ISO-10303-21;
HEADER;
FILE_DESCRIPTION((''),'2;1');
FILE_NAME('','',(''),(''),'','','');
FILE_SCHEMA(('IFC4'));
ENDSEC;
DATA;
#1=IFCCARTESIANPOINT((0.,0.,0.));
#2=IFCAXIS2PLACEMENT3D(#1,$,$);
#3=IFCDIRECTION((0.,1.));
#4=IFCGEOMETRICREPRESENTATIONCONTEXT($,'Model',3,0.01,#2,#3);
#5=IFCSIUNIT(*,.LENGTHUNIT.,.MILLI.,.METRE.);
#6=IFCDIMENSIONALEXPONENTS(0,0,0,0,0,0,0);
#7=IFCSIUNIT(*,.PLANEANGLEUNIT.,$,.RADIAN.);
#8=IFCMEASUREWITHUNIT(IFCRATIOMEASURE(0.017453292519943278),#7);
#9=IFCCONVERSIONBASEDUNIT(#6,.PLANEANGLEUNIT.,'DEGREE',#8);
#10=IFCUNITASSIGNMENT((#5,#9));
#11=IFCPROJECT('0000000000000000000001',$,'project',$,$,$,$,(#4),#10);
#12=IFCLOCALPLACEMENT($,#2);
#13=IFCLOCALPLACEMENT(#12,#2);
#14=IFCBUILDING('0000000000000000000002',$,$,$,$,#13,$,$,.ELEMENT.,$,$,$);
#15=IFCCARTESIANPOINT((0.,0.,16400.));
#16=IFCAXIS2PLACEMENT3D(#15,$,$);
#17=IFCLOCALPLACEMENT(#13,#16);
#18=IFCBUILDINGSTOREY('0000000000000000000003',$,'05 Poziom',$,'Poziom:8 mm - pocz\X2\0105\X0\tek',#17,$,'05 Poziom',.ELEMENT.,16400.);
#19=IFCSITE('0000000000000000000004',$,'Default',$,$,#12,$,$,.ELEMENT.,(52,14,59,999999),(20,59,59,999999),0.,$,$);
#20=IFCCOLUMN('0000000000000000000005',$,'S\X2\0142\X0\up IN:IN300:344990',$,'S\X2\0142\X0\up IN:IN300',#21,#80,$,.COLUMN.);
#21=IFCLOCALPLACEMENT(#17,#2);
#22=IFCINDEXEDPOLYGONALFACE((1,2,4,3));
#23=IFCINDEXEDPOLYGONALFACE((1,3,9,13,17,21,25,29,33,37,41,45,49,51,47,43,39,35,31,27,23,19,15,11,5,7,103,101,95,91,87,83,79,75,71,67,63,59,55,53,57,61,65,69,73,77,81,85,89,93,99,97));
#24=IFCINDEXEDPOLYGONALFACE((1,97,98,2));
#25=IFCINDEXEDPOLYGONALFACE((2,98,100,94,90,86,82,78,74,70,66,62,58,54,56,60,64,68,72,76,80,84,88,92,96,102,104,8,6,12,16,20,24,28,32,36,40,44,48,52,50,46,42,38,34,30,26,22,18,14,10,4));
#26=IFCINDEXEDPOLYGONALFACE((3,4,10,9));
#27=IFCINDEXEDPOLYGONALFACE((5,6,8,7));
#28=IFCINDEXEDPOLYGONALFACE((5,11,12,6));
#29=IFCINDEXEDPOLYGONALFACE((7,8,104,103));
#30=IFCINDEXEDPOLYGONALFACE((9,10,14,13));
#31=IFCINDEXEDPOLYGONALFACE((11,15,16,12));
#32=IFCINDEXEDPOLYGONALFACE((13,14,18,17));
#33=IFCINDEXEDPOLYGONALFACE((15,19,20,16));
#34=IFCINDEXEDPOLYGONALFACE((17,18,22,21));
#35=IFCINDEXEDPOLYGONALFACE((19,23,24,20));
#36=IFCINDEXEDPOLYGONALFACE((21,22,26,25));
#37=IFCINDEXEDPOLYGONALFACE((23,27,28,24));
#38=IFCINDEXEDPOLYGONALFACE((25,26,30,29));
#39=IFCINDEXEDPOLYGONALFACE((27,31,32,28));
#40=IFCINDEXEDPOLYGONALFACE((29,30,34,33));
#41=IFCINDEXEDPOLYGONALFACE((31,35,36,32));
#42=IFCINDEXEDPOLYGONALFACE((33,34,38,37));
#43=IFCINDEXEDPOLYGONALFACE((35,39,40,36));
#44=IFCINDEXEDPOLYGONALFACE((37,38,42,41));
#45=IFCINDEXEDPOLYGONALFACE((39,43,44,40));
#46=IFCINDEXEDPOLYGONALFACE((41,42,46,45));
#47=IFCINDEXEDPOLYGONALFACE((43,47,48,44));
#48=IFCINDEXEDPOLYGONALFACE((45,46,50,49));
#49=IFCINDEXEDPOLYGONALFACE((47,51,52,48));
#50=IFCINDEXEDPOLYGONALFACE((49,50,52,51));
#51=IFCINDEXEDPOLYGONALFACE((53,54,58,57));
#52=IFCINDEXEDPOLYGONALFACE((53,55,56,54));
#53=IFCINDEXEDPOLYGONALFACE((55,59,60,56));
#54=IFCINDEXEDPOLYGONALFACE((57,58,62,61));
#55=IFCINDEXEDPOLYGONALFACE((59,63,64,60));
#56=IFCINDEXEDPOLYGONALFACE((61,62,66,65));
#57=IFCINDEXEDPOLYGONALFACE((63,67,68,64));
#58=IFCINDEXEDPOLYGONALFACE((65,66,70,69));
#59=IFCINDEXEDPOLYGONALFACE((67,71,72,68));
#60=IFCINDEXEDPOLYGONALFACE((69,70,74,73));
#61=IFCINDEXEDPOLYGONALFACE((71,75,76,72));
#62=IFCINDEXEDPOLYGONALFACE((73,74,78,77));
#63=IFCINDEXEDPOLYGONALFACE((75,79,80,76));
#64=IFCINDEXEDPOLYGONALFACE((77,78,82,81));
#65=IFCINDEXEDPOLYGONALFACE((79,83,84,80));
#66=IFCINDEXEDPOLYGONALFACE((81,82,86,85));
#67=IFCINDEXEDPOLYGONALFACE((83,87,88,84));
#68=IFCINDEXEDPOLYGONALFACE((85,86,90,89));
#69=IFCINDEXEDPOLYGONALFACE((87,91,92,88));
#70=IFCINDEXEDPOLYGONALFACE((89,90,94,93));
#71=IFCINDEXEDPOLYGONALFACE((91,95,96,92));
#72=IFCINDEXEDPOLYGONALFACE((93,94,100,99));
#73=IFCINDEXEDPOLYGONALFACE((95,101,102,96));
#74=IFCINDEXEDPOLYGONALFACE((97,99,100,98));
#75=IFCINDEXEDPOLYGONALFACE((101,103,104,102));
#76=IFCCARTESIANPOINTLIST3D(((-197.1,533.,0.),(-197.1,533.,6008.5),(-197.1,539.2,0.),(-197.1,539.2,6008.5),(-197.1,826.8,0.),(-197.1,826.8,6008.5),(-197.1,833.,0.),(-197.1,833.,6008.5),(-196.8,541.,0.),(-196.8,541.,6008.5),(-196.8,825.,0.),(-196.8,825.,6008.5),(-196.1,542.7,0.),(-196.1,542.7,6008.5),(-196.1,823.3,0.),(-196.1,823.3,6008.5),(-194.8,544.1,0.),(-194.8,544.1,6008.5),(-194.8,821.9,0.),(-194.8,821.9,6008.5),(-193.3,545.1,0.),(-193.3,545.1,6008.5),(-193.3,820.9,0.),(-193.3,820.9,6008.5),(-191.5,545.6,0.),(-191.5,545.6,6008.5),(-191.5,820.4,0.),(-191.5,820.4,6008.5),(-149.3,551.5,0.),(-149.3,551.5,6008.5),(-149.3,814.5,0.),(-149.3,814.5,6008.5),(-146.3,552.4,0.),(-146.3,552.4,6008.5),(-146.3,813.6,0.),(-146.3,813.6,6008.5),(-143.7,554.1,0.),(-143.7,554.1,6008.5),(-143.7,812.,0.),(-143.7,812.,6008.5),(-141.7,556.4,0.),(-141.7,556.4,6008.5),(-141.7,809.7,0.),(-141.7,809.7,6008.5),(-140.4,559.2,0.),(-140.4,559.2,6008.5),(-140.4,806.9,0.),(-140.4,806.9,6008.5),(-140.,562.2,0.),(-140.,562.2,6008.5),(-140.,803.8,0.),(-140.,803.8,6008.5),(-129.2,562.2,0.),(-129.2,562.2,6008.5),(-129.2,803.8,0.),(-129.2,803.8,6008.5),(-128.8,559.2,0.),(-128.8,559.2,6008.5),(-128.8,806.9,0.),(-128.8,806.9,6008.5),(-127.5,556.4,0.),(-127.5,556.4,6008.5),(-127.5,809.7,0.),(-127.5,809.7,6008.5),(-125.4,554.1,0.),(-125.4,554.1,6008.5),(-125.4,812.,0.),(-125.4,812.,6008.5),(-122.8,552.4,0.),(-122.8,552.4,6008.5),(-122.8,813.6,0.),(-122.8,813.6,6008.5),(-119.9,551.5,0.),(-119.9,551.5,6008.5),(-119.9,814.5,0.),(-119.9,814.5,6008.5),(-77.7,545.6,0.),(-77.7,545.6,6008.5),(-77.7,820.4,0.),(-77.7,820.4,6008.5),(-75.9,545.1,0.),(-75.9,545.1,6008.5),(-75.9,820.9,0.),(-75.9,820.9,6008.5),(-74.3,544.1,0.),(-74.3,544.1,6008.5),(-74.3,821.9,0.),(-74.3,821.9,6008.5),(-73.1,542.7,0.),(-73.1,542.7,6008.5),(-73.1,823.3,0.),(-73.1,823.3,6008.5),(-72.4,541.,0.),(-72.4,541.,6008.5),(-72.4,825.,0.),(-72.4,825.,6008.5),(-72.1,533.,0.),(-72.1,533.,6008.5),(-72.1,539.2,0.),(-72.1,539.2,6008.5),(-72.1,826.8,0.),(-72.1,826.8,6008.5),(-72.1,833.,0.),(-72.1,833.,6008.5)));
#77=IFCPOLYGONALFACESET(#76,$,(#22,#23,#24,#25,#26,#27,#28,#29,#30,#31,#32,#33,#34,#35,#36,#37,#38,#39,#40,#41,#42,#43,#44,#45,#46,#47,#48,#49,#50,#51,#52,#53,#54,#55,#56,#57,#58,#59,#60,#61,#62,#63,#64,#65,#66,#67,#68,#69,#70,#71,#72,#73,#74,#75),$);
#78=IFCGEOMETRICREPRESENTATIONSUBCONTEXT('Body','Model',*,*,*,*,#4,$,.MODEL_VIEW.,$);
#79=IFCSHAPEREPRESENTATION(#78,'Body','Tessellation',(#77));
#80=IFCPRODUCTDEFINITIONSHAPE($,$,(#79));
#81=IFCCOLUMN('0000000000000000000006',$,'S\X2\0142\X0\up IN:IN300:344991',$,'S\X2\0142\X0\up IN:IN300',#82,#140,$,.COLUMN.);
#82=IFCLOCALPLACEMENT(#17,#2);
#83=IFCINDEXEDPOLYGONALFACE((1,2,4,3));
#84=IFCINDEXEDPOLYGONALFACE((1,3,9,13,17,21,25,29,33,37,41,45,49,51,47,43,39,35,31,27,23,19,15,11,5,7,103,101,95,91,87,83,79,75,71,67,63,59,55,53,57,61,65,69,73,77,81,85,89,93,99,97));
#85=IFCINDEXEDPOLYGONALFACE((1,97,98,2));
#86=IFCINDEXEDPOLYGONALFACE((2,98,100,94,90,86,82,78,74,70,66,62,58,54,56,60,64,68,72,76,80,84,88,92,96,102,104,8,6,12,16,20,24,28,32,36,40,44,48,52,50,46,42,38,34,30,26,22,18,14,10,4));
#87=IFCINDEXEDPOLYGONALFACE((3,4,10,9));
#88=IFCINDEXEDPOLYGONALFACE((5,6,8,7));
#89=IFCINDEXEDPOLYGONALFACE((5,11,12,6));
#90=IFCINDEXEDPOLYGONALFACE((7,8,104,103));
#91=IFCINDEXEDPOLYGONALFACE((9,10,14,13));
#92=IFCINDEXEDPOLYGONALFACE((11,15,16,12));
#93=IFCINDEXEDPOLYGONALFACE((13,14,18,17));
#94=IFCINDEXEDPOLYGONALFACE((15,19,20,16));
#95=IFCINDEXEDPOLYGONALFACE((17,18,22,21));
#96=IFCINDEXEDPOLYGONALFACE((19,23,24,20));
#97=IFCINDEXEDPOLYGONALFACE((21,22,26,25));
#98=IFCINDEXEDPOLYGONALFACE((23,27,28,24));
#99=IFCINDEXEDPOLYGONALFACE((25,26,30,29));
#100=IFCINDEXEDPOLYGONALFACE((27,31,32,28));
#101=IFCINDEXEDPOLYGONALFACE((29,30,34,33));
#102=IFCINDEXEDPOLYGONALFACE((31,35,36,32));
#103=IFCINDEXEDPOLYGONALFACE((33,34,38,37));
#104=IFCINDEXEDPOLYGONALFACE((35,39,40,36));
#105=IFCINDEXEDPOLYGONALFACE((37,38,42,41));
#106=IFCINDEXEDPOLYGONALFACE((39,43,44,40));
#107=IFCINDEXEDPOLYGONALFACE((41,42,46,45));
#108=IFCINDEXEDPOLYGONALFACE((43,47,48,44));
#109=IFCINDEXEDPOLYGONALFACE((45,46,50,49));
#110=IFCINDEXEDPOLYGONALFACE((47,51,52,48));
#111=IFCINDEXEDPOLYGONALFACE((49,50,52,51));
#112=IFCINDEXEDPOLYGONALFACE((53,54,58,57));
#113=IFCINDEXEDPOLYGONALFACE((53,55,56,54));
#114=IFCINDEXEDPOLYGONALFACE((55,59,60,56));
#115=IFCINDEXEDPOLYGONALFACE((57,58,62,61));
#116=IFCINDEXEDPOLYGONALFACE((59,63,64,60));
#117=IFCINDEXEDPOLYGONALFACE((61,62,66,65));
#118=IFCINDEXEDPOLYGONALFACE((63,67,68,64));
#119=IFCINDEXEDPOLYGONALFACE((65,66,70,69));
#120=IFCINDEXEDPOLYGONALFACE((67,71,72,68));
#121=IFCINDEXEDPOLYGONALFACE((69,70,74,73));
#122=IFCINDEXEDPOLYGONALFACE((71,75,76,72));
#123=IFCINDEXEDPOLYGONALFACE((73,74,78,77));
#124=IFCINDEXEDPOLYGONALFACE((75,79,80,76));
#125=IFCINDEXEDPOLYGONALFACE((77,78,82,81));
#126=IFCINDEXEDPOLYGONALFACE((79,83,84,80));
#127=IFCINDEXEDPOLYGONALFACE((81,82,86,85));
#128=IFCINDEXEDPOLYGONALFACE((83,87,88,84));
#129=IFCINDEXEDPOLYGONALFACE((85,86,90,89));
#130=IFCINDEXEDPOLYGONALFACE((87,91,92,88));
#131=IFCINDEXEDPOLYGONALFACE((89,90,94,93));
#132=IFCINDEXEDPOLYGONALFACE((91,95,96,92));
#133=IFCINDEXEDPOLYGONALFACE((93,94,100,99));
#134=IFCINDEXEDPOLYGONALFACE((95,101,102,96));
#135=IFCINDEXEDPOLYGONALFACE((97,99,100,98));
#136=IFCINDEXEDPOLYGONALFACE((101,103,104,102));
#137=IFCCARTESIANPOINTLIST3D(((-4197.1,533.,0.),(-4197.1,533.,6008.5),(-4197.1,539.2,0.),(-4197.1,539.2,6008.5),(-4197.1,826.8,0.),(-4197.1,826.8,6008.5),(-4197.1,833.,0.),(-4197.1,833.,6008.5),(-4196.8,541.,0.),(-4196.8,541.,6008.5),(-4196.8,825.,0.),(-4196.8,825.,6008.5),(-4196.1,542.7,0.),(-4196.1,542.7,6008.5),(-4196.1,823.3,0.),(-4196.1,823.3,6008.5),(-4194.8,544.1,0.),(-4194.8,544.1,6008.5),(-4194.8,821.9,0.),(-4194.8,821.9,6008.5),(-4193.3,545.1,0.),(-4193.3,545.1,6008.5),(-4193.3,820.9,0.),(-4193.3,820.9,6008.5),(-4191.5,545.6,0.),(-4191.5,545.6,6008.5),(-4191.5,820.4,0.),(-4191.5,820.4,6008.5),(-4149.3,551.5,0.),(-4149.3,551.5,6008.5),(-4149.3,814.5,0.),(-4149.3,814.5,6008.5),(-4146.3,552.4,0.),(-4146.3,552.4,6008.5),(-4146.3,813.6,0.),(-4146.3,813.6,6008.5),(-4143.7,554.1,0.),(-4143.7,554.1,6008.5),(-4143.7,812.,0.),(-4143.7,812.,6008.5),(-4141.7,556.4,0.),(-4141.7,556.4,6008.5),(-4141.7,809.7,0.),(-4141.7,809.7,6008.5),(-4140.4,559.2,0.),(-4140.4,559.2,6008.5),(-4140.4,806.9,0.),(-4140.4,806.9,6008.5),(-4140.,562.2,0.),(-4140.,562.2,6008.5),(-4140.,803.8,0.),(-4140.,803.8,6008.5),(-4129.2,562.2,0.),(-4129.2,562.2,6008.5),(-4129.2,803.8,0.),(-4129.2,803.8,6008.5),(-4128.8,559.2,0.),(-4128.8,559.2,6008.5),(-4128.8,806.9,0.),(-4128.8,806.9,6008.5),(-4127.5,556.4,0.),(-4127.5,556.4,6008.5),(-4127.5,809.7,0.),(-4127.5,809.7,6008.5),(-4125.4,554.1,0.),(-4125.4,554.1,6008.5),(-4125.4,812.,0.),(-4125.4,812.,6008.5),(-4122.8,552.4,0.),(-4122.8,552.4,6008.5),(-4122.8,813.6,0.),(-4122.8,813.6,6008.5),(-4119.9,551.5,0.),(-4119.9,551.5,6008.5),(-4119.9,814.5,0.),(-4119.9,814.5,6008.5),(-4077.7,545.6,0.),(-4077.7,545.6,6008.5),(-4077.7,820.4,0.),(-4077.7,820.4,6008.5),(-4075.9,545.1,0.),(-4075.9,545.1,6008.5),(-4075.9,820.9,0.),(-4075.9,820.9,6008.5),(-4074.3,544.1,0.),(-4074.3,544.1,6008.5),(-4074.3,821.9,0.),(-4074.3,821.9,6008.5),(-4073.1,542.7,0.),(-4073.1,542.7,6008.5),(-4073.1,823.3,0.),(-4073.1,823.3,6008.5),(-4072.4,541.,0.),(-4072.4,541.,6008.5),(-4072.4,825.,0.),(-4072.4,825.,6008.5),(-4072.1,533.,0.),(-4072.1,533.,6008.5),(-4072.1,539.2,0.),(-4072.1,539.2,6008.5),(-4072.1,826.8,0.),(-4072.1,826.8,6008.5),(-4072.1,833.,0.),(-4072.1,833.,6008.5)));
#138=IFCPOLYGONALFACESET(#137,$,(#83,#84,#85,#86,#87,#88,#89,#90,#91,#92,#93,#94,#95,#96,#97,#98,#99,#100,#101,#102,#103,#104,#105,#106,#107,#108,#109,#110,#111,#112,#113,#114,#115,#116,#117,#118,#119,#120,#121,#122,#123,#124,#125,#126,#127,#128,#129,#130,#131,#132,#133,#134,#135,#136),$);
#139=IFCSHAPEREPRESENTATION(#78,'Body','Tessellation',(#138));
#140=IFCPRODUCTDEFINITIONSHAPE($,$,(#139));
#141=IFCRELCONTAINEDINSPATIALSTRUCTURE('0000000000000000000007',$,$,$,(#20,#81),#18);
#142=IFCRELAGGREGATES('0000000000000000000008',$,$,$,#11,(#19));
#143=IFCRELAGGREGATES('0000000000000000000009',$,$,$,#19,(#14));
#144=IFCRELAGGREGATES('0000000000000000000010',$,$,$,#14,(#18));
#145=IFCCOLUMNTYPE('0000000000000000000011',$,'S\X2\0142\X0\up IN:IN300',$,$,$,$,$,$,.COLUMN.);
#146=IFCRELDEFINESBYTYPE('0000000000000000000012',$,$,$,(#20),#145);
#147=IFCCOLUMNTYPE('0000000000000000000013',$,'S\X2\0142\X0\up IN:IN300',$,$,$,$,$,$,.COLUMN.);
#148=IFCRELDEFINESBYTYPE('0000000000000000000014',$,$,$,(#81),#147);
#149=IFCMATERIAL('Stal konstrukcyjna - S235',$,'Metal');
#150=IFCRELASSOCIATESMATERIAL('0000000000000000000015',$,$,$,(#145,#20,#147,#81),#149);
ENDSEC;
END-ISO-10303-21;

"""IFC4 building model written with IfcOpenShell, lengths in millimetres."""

from ifc_helpers import new_model, entity, si_unit, converted_unit, direction, frame, origin, place, context, subcontext, project, spatial, line, arc, indexed_curve, outline, extrude, source, transform, mapped, material, type_object, type_shapes, element, save


model = new_model("IFC4")

# Units and contexts
model_context = context("Model", 3, precision=0.01, world=origin(), true_north=direction((0.0, 1.0)))
body_context = subcontext(model_context, "Body", "Model", "MODEL_VIEW")
ifc_project = project(units=[si_unit("LENGTHUNIT", "METRE", prefix="MILLI"), converted_unit("PLANEANGLEUNIT", "DEGREE", entity("IfcRatioMeasure", 0.017453292519943278), si_unit("PLANEANGLEUNIT", "RADIAN"), dimensions=[0, 0, 0, 0, 0, 0, 0])], contexts=[model_context])

# Site, building, storey
site_placement = place(None, origin())
site = spatial("IfcSite", under=ifc_project, at=site_placement, Name="Default", CompositionType="ELEMENT", RefLatitude=(52, 14, 59, 999999), RefLongitude=(20, 59, 59, 999999), RefElevation=0.0)
building_placement = place(site_placement, origin())
building = spatial("IfcBuilding", under=site, at=building_placement, CompositionType="ELEMENT")
storey_placement = place(building_placement, frame((0.0, 0.0, 16400.0)))
storey = spatial("IfcBuildingStorey", under=building, at=storey_placement, Name="05 Poziom", ObjectType="Poziom:8 mm - początek", LongName="05 Poziom", CompositionType="ELEMENT", Elevation=16400.0)

# Columns
ifc_material = material(Name="Stal konstrukcyjna - S235", Category="Metal")
column_type_1 = type_object("IfcColumnType", Name="Słup IN:IN300", PredefinedType="COLUMN", material=ifc_material)
shared_shape_1 = source(origin(), body_context, "Body", "SweptSolid", [
    extrude(outline(indexed_curve([(143.8, -62.5), (150.0, -62.5), (150.0, 62.5), (143.8, 62.5), (139.6, 60.9), (137.4, 56.9), (131.5, 14.7), (127.9, 8.1), (120.8, 5.4), (-120.8, 5.4), (-127.9, 8.1), (-131.5, 14.7), (-137.4, 56.9), (-139.6, 60.9), (-143.8, 62.5), (-150.0, 62.5), (-150.0, -62.5), (-143.8, -62.5), (-139.6, -60.9), (-137.4, -56.9), (-131.5, -14.7), (-127.9, -8.1), (-120.8, -5.4), (120.8, -5.4), (127.9, -8.1), (131.5, -14.7), (137.4, -56.9), (139.6, -60.9)], segments=[line(1, 2, 3, 4), arc(4, 5, 6), line(6, 7), arc(7, 8, 9), line(9, 10), arc(10, 11, 12), line(12, 13), arc(13, 14, 15), line(15, 16, 17, 18), arc(18, 19, 20), line(20, 21), arc(21, 22, 23), line(23, 24), arc(24, 25, 26), line(26, 27), arc(27, 28, 1)], self_intersect=False)), frame((-134.6, 683.0, 16400.0), z_axis=(0.0, 0.0, 1.0), x_axis=(0.0, -1.0, 0.0)), (0.0, 0.0, 1.0), 6008.5),
])
type_shapes(column_type_1, [shared_shape_1])
column_1_placement = place(storey_placement, frame((0.0, 0.0, -16400.0)))
element("IfcColumn", 1, at=column_1_placement, inside=storey, type_object=column_type_1, material=ifc_material, Name="Słup IN:IN300:344990", ObjectType="Słup IN:IN300", PredefinedType="COLUMN", context=body_context, shape_type="MappedRepresentation", body=[
    mapped(shared_shape_1, transform((0.0, 0.0, 0.0), scale=1.0)),
])
column_type_2 = type_object("IfcColumnType", Name="Słup IN:IN300", PredefinedType="COLUMN", material=ifc_material)
shared_shape_2 = source(origin(), body_context, "Body", "SweptSolid", [
    extrude(outline(indexed_curve([(143.8, -62.5), (150.0, -62.5), (150.0, 62.5), (143.8, 62.5), (139.6, 60.9), (137.4, 56.9), (131.5, 14.7), (127.9, 8.1), (120.8, 5.4), (-120.8, 5.4), (-127.9, 8.1), (-131.5, 14.7), (-137.4, 56.9), (-139.6, 60.9), (-143.8, 62.5), (-150.0, 62.5), (-150.0, -62.5), (-143.8, -62.5), (-139.6, -60.9), (-137.4, -56.9), (-131.5, -14.7), (-127.9, -8.1), (-120.8, -5.4), (120.8, -5.4), (127.9, -8.1), (131.5, -14.7), (137.4, -56.9), (139.6, -60.9)], segments=[line(1, 2, 3, 4), arc(4, 5, 6), line(6, 7), arc(7, 8, 9), line(9, 10), arc(10, 11, 12), line(12, 13), arc(13, 14, 15), line(15, 16, 17, 18), arc(18, 19, 20), line(20, 21), arc(21, 22, 23), line(23, 24), arc(24, 25, 26), line(26, 27), arc(27, 28, 1)], self_intersect=False)), frame((-4134.6, 683.0, 16400.0), z_axis=(0.0, 0.0, 1.0), x_axis=(0.0, -1.0, 0.0)), (0.0, 0.0, 1.0), 6008.5),
])
type_shapes(column_type_2, [shared_shape_2])
column_2_placement = place(storey_placement, frame((0.0, 0.0, -16400.0)))
element("IfcColumn", 2, at=column_2_placement, inside=storey, type_object=column_type_2, material=ifc_material, Name="Słup IN:IN300:344991", ObjectType="Słup IN:IN300", PredefinedType="COLUMN", context=body_context, shape_type="MappedRepresentation", body=[
    mapped(shared_shape_2, transform((0.0, 0.0, 0.0), scale=1.0)),
])

save(model, "model.ifc")
